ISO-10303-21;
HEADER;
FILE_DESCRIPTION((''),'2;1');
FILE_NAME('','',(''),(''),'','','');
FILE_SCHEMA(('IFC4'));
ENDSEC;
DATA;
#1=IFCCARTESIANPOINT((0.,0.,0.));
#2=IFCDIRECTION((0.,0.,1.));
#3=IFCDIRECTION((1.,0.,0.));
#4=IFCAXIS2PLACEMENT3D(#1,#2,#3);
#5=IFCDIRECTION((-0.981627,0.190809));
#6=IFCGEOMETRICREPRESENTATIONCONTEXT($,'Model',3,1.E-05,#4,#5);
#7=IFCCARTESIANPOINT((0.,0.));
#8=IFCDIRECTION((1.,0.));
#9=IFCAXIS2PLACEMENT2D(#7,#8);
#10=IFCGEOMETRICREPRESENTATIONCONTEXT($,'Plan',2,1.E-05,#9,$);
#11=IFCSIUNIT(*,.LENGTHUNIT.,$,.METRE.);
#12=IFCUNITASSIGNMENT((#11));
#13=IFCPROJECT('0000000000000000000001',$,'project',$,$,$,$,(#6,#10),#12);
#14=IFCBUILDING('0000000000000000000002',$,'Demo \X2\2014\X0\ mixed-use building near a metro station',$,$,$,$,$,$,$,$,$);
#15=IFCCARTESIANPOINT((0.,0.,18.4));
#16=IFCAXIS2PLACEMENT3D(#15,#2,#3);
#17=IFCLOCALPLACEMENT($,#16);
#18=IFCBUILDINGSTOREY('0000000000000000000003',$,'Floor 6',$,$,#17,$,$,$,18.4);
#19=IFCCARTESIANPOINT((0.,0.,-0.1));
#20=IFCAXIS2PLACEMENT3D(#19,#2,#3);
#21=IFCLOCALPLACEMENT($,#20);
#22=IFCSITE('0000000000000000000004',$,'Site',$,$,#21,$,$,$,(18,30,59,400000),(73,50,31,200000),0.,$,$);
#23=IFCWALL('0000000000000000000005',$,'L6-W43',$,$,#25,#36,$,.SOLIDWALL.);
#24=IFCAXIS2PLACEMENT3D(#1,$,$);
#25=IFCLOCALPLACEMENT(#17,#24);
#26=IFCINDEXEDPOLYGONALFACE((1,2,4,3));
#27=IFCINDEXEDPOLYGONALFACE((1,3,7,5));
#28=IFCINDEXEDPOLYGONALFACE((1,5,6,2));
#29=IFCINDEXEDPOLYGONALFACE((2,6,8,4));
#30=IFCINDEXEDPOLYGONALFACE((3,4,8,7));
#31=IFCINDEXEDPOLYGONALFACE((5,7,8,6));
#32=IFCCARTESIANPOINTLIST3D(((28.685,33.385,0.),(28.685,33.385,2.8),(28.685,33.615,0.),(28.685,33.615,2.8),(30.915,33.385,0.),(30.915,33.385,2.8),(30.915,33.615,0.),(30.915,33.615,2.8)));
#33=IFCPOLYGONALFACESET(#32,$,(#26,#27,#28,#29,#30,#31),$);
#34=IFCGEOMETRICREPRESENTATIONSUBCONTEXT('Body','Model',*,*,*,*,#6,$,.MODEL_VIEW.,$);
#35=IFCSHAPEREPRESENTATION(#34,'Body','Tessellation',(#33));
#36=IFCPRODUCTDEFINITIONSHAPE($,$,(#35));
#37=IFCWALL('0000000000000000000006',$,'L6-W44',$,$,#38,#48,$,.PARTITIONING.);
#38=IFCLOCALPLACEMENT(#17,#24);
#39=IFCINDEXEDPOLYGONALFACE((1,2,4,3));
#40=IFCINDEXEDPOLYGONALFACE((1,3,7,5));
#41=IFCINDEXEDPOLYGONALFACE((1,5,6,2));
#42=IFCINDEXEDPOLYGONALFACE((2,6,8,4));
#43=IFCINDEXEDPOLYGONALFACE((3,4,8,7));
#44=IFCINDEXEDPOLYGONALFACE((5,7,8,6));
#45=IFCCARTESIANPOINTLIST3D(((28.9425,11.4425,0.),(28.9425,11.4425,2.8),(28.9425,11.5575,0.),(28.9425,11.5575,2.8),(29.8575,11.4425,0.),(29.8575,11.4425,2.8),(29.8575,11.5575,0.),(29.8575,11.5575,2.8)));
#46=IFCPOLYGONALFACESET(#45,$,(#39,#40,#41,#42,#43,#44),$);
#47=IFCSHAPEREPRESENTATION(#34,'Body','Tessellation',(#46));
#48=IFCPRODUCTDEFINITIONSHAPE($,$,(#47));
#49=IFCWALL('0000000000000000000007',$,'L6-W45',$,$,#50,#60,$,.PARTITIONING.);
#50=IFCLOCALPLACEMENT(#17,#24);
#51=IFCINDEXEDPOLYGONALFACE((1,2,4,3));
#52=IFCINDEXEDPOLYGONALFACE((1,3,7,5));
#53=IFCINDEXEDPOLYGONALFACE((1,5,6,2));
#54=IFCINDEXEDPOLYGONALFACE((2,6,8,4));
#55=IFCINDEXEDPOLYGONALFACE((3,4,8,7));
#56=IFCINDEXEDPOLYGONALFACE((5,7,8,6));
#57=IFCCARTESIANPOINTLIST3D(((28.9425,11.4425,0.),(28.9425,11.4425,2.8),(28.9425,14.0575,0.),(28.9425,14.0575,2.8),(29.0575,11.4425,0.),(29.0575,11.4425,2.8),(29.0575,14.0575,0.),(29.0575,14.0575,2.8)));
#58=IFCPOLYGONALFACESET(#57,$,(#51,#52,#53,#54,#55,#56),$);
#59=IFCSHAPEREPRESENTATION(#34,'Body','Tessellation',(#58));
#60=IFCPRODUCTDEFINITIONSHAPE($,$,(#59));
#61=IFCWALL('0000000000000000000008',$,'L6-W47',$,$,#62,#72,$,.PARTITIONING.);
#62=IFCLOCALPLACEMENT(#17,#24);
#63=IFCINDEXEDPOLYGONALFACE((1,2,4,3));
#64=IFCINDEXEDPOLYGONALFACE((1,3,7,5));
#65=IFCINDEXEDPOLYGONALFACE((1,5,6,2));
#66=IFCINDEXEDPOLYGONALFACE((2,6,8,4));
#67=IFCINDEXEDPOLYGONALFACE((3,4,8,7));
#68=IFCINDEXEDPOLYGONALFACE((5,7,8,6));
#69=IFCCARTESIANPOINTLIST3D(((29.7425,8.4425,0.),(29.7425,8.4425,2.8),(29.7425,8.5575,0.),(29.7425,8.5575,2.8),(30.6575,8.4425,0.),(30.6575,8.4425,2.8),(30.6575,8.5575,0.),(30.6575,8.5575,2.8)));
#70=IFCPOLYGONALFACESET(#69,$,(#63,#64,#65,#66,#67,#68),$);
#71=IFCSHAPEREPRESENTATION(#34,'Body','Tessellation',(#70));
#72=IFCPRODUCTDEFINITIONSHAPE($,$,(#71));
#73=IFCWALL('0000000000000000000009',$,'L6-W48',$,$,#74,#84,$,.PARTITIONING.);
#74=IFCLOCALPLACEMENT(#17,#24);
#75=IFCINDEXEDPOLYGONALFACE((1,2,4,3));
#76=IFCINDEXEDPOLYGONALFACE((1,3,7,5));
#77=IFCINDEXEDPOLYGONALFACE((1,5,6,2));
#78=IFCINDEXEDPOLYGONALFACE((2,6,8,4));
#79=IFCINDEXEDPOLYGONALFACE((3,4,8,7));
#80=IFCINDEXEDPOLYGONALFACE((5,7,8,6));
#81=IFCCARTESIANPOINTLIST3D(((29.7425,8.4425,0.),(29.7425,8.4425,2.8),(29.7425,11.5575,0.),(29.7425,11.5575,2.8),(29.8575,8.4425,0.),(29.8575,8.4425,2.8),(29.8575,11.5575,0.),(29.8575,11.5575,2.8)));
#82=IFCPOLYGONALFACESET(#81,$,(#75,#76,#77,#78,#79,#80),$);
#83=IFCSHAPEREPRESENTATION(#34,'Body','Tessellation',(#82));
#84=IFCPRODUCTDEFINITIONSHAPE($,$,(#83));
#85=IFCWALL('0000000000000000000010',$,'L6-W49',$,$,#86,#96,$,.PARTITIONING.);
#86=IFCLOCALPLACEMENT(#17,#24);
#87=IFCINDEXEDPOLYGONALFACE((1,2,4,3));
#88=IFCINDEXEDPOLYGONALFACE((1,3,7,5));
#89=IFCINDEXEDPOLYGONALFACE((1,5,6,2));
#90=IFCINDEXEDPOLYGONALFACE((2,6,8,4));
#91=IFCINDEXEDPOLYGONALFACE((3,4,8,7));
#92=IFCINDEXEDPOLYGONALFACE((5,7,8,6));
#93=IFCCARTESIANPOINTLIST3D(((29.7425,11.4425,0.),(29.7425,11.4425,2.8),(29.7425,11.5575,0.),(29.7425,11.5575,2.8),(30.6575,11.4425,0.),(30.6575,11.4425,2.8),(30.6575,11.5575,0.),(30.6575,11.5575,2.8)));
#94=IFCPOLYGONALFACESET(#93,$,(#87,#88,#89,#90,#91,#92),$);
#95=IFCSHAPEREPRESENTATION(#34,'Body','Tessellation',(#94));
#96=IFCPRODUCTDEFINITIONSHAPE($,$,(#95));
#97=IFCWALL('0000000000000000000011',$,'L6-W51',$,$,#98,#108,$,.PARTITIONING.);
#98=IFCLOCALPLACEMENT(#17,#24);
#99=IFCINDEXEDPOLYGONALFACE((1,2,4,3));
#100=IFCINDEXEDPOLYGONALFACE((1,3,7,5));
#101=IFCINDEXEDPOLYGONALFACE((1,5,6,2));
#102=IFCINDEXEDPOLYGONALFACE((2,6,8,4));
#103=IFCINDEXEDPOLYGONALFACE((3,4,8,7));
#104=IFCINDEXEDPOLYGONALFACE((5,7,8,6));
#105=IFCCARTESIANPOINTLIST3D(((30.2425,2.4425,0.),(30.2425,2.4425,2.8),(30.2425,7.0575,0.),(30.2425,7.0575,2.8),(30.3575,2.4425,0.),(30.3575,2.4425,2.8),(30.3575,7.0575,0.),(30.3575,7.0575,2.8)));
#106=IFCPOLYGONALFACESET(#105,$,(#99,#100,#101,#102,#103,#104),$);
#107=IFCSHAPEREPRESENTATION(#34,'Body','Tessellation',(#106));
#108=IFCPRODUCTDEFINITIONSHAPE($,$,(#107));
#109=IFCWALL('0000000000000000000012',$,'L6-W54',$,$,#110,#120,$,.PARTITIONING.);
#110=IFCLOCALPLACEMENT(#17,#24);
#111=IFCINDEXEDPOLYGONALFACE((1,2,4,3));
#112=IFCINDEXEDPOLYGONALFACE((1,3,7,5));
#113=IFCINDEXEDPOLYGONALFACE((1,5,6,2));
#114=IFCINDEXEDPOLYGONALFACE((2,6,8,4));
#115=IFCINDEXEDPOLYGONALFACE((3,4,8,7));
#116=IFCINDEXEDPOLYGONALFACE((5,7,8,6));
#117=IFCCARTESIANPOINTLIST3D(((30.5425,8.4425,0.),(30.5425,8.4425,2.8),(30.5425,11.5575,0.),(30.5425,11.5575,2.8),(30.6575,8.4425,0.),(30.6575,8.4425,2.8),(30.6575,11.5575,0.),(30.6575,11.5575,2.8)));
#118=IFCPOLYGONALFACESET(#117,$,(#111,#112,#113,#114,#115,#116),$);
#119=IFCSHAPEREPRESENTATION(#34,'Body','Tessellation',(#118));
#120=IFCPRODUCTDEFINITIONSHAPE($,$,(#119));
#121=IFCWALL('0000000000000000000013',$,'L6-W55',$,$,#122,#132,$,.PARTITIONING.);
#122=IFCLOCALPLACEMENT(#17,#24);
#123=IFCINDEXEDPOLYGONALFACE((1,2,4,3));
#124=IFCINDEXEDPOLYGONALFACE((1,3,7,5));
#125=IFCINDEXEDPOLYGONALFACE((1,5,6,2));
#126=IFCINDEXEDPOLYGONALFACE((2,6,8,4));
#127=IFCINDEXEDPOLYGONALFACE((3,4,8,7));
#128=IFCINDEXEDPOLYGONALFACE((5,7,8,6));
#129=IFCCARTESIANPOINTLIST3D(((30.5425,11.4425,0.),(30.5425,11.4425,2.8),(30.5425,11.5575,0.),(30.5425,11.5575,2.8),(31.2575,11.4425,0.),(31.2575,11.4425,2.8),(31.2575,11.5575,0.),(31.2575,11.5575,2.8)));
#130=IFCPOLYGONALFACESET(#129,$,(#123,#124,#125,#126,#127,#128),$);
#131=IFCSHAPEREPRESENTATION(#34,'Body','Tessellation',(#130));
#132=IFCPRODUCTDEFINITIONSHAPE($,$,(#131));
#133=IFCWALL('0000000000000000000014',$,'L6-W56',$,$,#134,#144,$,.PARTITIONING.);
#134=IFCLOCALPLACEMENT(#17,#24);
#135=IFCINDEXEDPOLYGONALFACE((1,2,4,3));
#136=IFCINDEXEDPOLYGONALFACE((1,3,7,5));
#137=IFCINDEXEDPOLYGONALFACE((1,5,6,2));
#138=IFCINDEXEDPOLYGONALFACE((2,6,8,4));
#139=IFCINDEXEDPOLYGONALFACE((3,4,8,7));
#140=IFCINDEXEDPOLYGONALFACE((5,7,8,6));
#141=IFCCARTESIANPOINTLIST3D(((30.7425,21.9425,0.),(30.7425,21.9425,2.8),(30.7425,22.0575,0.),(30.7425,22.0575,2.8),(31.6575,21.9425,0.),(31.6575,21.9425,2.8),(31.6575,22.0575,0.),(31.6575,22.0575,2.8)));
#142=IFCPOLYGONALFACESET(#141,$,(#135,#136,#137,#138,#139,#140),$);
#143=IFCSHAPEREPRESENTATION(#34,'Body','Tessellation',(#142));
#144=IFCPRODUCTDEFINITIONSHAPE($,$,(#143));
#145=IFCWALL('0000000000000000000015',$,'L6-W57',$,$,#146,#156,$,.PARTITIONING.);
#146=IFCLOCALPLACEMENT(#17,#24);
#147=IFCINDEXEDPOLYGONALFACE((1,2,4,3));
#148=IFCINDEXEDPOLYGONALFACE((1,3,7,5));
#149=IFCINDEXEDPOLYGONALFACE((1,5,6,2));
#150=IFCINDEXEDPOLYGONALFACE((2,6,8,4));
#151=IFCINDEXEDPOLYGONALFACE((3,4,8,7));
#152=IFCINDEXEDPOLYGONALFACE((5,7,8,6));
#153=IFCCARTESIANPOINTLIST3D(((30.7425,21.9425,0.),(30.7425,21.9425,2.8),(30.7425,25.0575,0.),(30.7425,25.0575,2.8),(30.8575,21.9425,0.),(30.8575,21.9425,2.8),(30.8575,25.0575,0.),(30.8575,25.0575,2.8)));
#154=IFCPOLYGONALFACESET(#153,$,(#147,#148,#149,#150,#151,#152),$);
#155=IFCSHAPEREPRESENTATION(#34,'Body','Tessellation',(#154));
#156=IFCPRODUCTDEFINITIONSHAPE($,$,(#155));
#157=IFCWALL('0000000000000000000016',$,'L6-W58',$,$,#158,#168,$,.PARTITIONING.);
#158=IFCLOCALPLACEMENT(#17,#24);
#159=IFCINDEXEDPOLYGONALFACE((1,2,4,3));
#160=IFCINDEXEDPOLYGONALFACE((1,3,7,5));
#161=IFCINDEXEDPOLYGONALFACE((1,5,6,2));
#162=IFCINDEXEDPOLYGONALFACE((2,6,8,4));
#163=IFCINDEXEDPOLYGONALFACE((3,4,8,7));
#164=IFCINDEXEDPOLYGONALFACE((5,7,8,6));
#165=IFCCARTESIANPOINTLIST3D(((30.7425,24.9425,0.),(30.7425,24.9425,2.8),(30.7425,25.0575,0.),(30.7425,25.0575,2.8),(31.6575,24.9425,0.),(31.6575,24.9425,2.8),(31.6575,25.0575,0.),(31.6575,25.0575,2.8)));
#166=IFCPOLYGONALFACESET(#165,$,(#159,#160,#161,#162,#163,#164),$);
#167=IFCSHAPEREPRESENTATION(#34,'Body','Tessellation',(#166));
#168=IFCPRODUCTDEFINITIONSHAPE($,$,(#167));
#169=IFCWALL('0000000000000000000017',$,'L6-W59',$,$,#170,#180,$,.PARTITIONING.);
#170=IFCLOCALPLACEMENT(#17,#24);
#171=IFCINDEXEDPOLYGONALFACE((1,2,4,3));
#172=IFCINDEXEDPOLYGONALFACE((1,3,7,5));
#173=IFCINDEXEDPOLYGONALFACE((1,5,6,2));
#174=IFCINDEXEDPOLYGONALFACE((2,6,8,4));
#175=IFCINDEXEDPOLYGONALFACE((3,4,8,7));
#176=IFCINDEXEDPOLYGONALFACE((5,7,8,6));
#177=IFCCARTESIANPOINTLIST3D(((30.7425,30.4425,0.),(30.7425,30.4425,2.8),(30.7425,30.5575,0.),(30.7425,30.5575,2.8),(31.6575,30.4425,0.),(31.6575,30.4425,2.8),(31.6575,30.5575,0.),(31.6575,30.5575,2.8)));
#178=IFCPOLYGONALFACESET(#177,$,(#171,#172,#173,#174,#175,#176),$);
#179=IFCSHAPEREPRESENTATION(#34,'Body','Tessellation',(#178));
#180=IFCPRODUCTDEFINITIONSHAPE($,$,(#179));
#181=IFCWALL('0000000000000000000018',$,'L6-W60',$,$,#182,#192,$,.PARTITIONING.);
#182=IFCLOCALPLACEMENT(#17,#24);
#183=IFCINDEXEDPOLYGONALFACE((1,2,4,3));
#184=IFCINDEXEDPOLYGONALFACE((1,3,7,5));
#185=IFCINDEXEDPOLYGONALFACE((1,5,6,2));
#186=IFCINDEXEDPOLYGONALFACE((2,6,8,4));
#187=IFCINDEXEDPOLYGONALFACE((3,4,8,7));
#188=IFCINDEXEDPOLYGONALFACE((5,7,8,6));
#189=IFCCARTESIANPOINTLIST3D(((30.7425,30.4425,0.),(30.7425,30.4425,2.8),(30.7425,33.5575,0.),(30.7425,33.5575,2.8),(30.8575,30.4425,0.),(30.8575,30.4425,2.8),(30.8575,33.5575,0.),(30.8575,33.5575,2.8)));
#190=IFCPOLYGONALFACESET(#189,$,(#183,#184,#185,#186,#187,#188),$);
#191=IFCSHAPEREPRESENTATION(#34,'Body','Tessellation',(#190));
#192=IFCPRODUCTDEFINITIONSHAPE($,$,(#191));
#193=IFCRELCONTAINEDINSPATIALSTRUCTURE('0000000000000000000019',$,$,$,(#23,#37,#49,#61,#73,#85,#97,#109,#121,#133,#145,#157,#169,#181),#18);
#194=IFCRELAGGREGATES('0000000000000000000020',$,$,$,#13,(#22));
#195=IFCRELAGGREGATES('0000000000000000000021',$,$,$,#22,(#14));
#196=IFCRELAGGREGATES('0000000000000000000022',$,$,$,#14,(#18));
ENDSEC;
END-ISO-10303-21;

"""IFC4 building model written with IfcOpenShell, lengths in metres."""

from ifc_helpers import new_model, si_unit, direction, frame, origin_with_axes, origin_2d_with_axis, place, context, subcontext, project, spatial, line, indexed_curve, outline, extrude, element, save


model = new_model("IFC4")

# Units and contexts
model_context = context("Model", 3, precision=1e-05, world=origin_with_axes(), true_north=direction((-0.981627, 0.190809)))
plan_context = context("Plan", 2, precision=1e-05, world=origin_2d_with_axis())
body_context = subcontext(model_context, "Body", "Model", "MODEL_VIEW")
ifc_project = project(units=[si_unit("LENGTHUNIT", "METRE")], contexts=[model_context, plan_context])

# Site, building, storey
site_placement = place(None, frame((0.0, 0.0, -0.1), z_axis=(0.0, 0.0, 1.0), x_axis=(1.0, 0.0, 0.0)))
site = spatial("IfcSite", under=ifc_project, at=site_placement, Name="Site", RefLatitude=(18, 30, 59, 400000), RefLongitude=(73, 50, 31, 200000), RefElevation=0.0)
building = spatial("IfcBuilding", under=site, Name="Demo — mixed-use building near a metro station")
storey_placement = place(None, frame((0.0, 0.0, 18.4), z_axis=(0.0, 0.0, 1.0), x_axis=(1.0, 0.0, 0.0)))
storey = spatial("IfcBuildingStorey", under=building, at=storey_placement, Name="Floor 6", Elevation=18.4)

# Walls
wall_1_placement = place(storey_placement, frame((0.0, 0.0, -18.4), z_axis=(0.0, 0.0, 1.0), x_axis=(1.0, 0.0, 0.0)))
element("IfcWall", 1, at=wall_1_placement, inside=storey, Name="L6-W43", PredefinedType="SOLIDWALL", context=body_context, shape_type="SweptSolid", body=[
    extrude(outline(indexed_curve([(30.915, 33.385), (28.685, 33.385), (28.685, 33.615), (30.915, 33.615)], segments=[line(1, 2, 3, 4, 1)])), frame((0.0, 0.0, 18.4), z_axis=(0.0, 0.0, 1.0), x_axis=(1.0, 0.0, 0.0)), (0.0, 0.0, 1.0), 2.8),
])
wall_2_placement = place(storey_placement, frame((0.0, 0.0, -18.4), z_axis=(0.0, 0.0, 1.0), x_axis=(1.0, 0.0, 0.0)))
element("IfcWall", 2, at=wall_2_placement, inside=storey, Name="L6-W44", PredefinedType="PARTITIONING", context=body_context, shape_type="SweptSolid", body=[
    extrude(outline(indexed_curve([(28.9425, 11.5575), (29.8575, 11.5575), (29.8575, 11.4425), (28.9425, 11.4425)], segments=[line(1, 2, 3, 4, 1)])), frame((0.0, 0.0, 18.4), z_axis=(0.0, 0.0, 1.0), x_axis=(1.0, 0.0, 0.0)), (0.0, 0.0, 1.0), 2.8),
])
wall_3_placement = place(storey_placement, frame((0.0, 0.0, -18.4), z_axis=(0.0, 0.0, 1.0), x_axis=(1.0, 0.0, 0.0)))
element("IfcWall", 3, at=wall_3_placement, inside=storey, Name="L6-W45", PredefinedType="PARTITIONING", context=body_context, shape_type="SweptSolid", body=[
    extrude(outline(indexed_curve([(28.9425, 11.4425), (28.9425, 14.0575), (29.0575, 14.0575), (29.0575, 11.4425)], segments=[line(1, 2, 3, 4, 1)])), frame((0.0, 0.0, 18.4), z_axis=(0.0, 0.0, 1.0), x_axis=(1.0, 0.0, 0.0)), (0.0, 0.0, 1.0), 2.8),
])

# Walls
wall_4_placement = place(storey_placement, frame((0.0, 0.0, -18.4), z_axis=(0.0, 0.0, 1.0), x_axis=(1.0, 0.0, 0.0)))
element("IfcWall", 4, at=wall_4_placement, inside=storey, Name="L6-W47", PredefinedType="PARTITIONING", context=body_context, shape_type="SweptSolid", body=[
    extrude(outline(indexed_curve([(30.6575, 8.4425), (29.7425, 8.4425), (29.7425, 8.5575), (30.6575, 8.5575)], segments=[line(1, 2, 3, 4, 1)])), frame((0.0, 0.0, 18.4), z_axis=(0.0, 0.0, 1.0), x_axis=(1.0, 0.0, 0.0)), (0.0, 0.0, 1.0), 2.8),
])
wall_5_placement = place(storey_placement, frame((0.0, 0.0, -18.4), z_axis=(0.0, 0.0, 1.0), x_axis=(1.0, 0.0, 0.0)))
element("IfcWall", 5, at=wall_5_placement, inside=storey, Name="L6-W48", PredefinedType="PARTITIONING", context=body_context, shape_type="SweptSolid", body=[
    extrude(outline(indexed_curve([(29.7425, 8.4425), (29.7425, 11.5575), (29.8575, 11.5575), (29.8575, 8.4425)], segments=[line(1, 2, 3, 4, 1)])), frame((0.0, 0.0, 18.4), z_axis=(0.0, 0.0, 1.0), x_axis=(1.0, 0.0, 0.0)), (0.0, 0.0, 1.0), 2.8),
])
wall_6_placement = place(storey_placement, frame((0.0, 0.0, -18.4), z_axis=(0.0, 0.0, 1.0), x_axis=(1.0, 0.0, 0.0)))
element("IfcWall", 6, at=wall_6_placement, inside=storey, Name="L6-W49", PredefinedType="PARTITIONING", context=body_context, shape_type="SweptSolid", body=[
    extrude(outline(indexed_curve([(29.7425, 11.5575), (30.6575, 11.5575), (30.6575, 11.4425), (29.7425, 11.4425)], segments=[line(1, 2, 3, 4, 1)])), frame((0.0, 0.0, 18.4), z_axis=(0.0, 0.0, 1.0), x_axis=(1.0, 0.0, 0.0)), (0.0, 0.0, 1.0), 2.8),
])

# Wall
wall_7_placement = place(storey_placement, frame((0.0, 0.0, -18.4), z_axis=(0.0, 0.0, 1.0), x_axis=(1.0, 0.0, 0.0)))
element("IfcWall", 7, at=wall_7_placement, inside=storey, Name="L6-W51", PredefinedType="PARTITIONING", context=body_context, shape_type="SweptSolid", body=[
    extrude(outline(indexed_curve([(30.2425, 2.4425), (30.2425, 7.0575), (30.3575, 7.0575), (30.3575, 2.4425)], segments=[line(1, 2, 3, 4, 1)])), frame((0.0, 0.0, 18.4), z_axis=(0.0, 0.0, 1.0), x_axis=(1.0, 0.0, 0.0)), (0.0, 0.0, 1.0), 2.8),
])

# Walls
wall_8_placement = place(storey_placement, frame((0.0, 0.0, -18.4), z_axis=(0.0, 0.0, 1.0), x_axis=(1.0, 0.0, 0.0)))
element("IfcWall", 8, at=wall_8_placement, inside=storey, Name="L6-W54", PredefinedType="PARTITIONING", context=body_context, shape_type="SweptSolid", body=[
    extrude(outline(indexed_curve([(30.5425, 8.4425), (30.5425, 11.5575), (30.6575, 11.5575), (30.6575, 8.4425)], segments=[line(1, 2, 3, 4, 1)])), frame((0.0, 0.0, 18.4), z_axis=(0.0, 0.0, 1.0), x_axis=(1.0, 0.0, 0.0)), (0.0, 0.0, 1.0), 2.8),
])
wall_9_placement = place(storey_placement, frame((0.0, 0.0, -18.4), z_axis=(0.0, 0.0, 1.0), x_axis=(1.0, 0.0, 0.0)))
element("IfcWall", 9, at=wall_9_placement, inside=storey, Name="L6-W55", PredefinedType="PARTITIONING", context=body_context, shape_type="SweptSolid", body=[
    extrude(outline(indexed_curve([(30.5425, 11.5575), (31.2575, 11.5575), (31.2575, 11.4425), (30.5425, 11.4425)], segments=[line(1, 2, 3, 4, 1)])), frame((0.0, 0.0, 18.4), z_axis=(0.0, 0.0, 1.0), x_axis=(1.0, 0.0, 0.0)), (0.0, 0.0, 1.0), 2.8),
])
wall_10_placement = place(storey_placement, frame((0.0, 0.0, -18.4), z_axis=(0.0, 0.0, 1.0), x_axis=(1.0, 0.0, 0.0)))
element("IfcWall", 10, at=wall_10_placement, inside=storey, Name="L6-W56", PredefinedType="PARTITIONING", context=body_context, shape_type="SweptSolid", body=[
    extrude(outline(indexed_curve([(31.6575, 21.9425), (30.7425, 21.9425), (30.7425, 22.0575), (31.6575, 22.0575)], segments=[line(1, 2, 3, 4, 1)])), frame((0.0, 0.0, 18.4), z_axis=(0.0, 0.0, 1.0), x_axis=(1.0, 0.0, 0.0)), (0.0, 0.0, 1.0), 2.8),
])
wall_11_placement = place(storey_placement, frame((0.0, 0.0, -18.4), z_axis=(0.0, 0.0, 1.0), x_axis=(1.0, 0.0, 0.0)))
element("IfcWall", 11, at=wall_11_placement, inside=storey, Name="L6-W57", PredefinedType="PARTITIONING", context=body_context, shape_type="SweptSolid", body=[
    extrude(outline(indexed_curve([(30.7425, 21.9425), (30.7425, 25.0575), (30.8575, 25.0575), (30.8575, 21.9425)], segments=[line(1, 2, 3, 4, 1)])), frame((0.0, 0.0, 18.4), z_axis=(0.0, 0.0, 1.0), x_axis=(1.0, 0.0, 0.0)), (0.0, 0.0, 1.0), 2.8),
])
wall_12_placement = place(storey_placement, frame((0.0, 0.0, -18.4), z_axis=(0.0, 0.0, 1.0), x_axis=(1.0, 0.0, 0.0)))
element("IfcWall", 12, at=wall_12_placement, inside=storey, Name="L6-W58", PredefinedType="PARTITIONING", context=body_context, shape_type="SweptSolid", body=[
    extrude(outline(indexed_curve([(31.6575, 24.9425), (30.7425, 24.9425), (30.7425, 25.0575), (31.6575, 25.0575)], segments=[line(1, 2, 3, 4, 1)])), frame((0.0, 0.0, 18.4), z_axis=(0.0, 0.0, 1.0), x_axis=(1.0, 0.0, 0.0)), (0.0, 0.0, 1.0), 2.8),
])
wall_13_placement = place(storey_placement, frame((0.0, 0.0, -18.4), z_axis=(0.0, 0.0, 1.0), x_axis=(1.0, 0.0, 0.0)))
element("IfcWall", 13, at=wall_13_placement, inside=storey, Name="L6-W59", PredefinedType="PARTITIONING", context=body_context, shape_type="SweptSolid", body=[
    extrude(outline(indexed_curve([(31.6575, 30.4425), (30.7425, 30.4425), (30.7425, 30.5575), (31.6575, 30.5575)], segments=[line(1, 2, 3, 4, 1)])), frame((0.0, 0.0, 18.4), z_axis=(0.0, 0.0, 1.0), x_axis=(1.0, 0.0, 0.0)), (0.0, 0.0, 1.0), 2.8),
])
wall_14_placement = place(storey_placement, frame((0.0, 0.0, -18.4), z_axis=(0.0, 0.0, 1.0), x_axis=(1.0, 0.0, 0.0)))
element("IfcWall", 14, at=wall_14_placement, inside=storey, Name="L6-W60", PredefinedType="PARTITIONING", context=body_context, shape_type="SweptSolid", body=[
    extrude(outline(indexed_curve([(30.7425, 30.4425), (30.7425, 33.5575), (30.8575, 33.5575), (30.8575, 30.4425)], segments=[line(1, 2, 3, 4, 1)])), frame((0.0, 0.0, 18.4), z_axis=(0.0, 0.0, 1.0), x_axis=(1.0, 0.0, 0.0)), (0.0, 0.0, 1.0), 2.8),
])

save(model, "model.ifc")
